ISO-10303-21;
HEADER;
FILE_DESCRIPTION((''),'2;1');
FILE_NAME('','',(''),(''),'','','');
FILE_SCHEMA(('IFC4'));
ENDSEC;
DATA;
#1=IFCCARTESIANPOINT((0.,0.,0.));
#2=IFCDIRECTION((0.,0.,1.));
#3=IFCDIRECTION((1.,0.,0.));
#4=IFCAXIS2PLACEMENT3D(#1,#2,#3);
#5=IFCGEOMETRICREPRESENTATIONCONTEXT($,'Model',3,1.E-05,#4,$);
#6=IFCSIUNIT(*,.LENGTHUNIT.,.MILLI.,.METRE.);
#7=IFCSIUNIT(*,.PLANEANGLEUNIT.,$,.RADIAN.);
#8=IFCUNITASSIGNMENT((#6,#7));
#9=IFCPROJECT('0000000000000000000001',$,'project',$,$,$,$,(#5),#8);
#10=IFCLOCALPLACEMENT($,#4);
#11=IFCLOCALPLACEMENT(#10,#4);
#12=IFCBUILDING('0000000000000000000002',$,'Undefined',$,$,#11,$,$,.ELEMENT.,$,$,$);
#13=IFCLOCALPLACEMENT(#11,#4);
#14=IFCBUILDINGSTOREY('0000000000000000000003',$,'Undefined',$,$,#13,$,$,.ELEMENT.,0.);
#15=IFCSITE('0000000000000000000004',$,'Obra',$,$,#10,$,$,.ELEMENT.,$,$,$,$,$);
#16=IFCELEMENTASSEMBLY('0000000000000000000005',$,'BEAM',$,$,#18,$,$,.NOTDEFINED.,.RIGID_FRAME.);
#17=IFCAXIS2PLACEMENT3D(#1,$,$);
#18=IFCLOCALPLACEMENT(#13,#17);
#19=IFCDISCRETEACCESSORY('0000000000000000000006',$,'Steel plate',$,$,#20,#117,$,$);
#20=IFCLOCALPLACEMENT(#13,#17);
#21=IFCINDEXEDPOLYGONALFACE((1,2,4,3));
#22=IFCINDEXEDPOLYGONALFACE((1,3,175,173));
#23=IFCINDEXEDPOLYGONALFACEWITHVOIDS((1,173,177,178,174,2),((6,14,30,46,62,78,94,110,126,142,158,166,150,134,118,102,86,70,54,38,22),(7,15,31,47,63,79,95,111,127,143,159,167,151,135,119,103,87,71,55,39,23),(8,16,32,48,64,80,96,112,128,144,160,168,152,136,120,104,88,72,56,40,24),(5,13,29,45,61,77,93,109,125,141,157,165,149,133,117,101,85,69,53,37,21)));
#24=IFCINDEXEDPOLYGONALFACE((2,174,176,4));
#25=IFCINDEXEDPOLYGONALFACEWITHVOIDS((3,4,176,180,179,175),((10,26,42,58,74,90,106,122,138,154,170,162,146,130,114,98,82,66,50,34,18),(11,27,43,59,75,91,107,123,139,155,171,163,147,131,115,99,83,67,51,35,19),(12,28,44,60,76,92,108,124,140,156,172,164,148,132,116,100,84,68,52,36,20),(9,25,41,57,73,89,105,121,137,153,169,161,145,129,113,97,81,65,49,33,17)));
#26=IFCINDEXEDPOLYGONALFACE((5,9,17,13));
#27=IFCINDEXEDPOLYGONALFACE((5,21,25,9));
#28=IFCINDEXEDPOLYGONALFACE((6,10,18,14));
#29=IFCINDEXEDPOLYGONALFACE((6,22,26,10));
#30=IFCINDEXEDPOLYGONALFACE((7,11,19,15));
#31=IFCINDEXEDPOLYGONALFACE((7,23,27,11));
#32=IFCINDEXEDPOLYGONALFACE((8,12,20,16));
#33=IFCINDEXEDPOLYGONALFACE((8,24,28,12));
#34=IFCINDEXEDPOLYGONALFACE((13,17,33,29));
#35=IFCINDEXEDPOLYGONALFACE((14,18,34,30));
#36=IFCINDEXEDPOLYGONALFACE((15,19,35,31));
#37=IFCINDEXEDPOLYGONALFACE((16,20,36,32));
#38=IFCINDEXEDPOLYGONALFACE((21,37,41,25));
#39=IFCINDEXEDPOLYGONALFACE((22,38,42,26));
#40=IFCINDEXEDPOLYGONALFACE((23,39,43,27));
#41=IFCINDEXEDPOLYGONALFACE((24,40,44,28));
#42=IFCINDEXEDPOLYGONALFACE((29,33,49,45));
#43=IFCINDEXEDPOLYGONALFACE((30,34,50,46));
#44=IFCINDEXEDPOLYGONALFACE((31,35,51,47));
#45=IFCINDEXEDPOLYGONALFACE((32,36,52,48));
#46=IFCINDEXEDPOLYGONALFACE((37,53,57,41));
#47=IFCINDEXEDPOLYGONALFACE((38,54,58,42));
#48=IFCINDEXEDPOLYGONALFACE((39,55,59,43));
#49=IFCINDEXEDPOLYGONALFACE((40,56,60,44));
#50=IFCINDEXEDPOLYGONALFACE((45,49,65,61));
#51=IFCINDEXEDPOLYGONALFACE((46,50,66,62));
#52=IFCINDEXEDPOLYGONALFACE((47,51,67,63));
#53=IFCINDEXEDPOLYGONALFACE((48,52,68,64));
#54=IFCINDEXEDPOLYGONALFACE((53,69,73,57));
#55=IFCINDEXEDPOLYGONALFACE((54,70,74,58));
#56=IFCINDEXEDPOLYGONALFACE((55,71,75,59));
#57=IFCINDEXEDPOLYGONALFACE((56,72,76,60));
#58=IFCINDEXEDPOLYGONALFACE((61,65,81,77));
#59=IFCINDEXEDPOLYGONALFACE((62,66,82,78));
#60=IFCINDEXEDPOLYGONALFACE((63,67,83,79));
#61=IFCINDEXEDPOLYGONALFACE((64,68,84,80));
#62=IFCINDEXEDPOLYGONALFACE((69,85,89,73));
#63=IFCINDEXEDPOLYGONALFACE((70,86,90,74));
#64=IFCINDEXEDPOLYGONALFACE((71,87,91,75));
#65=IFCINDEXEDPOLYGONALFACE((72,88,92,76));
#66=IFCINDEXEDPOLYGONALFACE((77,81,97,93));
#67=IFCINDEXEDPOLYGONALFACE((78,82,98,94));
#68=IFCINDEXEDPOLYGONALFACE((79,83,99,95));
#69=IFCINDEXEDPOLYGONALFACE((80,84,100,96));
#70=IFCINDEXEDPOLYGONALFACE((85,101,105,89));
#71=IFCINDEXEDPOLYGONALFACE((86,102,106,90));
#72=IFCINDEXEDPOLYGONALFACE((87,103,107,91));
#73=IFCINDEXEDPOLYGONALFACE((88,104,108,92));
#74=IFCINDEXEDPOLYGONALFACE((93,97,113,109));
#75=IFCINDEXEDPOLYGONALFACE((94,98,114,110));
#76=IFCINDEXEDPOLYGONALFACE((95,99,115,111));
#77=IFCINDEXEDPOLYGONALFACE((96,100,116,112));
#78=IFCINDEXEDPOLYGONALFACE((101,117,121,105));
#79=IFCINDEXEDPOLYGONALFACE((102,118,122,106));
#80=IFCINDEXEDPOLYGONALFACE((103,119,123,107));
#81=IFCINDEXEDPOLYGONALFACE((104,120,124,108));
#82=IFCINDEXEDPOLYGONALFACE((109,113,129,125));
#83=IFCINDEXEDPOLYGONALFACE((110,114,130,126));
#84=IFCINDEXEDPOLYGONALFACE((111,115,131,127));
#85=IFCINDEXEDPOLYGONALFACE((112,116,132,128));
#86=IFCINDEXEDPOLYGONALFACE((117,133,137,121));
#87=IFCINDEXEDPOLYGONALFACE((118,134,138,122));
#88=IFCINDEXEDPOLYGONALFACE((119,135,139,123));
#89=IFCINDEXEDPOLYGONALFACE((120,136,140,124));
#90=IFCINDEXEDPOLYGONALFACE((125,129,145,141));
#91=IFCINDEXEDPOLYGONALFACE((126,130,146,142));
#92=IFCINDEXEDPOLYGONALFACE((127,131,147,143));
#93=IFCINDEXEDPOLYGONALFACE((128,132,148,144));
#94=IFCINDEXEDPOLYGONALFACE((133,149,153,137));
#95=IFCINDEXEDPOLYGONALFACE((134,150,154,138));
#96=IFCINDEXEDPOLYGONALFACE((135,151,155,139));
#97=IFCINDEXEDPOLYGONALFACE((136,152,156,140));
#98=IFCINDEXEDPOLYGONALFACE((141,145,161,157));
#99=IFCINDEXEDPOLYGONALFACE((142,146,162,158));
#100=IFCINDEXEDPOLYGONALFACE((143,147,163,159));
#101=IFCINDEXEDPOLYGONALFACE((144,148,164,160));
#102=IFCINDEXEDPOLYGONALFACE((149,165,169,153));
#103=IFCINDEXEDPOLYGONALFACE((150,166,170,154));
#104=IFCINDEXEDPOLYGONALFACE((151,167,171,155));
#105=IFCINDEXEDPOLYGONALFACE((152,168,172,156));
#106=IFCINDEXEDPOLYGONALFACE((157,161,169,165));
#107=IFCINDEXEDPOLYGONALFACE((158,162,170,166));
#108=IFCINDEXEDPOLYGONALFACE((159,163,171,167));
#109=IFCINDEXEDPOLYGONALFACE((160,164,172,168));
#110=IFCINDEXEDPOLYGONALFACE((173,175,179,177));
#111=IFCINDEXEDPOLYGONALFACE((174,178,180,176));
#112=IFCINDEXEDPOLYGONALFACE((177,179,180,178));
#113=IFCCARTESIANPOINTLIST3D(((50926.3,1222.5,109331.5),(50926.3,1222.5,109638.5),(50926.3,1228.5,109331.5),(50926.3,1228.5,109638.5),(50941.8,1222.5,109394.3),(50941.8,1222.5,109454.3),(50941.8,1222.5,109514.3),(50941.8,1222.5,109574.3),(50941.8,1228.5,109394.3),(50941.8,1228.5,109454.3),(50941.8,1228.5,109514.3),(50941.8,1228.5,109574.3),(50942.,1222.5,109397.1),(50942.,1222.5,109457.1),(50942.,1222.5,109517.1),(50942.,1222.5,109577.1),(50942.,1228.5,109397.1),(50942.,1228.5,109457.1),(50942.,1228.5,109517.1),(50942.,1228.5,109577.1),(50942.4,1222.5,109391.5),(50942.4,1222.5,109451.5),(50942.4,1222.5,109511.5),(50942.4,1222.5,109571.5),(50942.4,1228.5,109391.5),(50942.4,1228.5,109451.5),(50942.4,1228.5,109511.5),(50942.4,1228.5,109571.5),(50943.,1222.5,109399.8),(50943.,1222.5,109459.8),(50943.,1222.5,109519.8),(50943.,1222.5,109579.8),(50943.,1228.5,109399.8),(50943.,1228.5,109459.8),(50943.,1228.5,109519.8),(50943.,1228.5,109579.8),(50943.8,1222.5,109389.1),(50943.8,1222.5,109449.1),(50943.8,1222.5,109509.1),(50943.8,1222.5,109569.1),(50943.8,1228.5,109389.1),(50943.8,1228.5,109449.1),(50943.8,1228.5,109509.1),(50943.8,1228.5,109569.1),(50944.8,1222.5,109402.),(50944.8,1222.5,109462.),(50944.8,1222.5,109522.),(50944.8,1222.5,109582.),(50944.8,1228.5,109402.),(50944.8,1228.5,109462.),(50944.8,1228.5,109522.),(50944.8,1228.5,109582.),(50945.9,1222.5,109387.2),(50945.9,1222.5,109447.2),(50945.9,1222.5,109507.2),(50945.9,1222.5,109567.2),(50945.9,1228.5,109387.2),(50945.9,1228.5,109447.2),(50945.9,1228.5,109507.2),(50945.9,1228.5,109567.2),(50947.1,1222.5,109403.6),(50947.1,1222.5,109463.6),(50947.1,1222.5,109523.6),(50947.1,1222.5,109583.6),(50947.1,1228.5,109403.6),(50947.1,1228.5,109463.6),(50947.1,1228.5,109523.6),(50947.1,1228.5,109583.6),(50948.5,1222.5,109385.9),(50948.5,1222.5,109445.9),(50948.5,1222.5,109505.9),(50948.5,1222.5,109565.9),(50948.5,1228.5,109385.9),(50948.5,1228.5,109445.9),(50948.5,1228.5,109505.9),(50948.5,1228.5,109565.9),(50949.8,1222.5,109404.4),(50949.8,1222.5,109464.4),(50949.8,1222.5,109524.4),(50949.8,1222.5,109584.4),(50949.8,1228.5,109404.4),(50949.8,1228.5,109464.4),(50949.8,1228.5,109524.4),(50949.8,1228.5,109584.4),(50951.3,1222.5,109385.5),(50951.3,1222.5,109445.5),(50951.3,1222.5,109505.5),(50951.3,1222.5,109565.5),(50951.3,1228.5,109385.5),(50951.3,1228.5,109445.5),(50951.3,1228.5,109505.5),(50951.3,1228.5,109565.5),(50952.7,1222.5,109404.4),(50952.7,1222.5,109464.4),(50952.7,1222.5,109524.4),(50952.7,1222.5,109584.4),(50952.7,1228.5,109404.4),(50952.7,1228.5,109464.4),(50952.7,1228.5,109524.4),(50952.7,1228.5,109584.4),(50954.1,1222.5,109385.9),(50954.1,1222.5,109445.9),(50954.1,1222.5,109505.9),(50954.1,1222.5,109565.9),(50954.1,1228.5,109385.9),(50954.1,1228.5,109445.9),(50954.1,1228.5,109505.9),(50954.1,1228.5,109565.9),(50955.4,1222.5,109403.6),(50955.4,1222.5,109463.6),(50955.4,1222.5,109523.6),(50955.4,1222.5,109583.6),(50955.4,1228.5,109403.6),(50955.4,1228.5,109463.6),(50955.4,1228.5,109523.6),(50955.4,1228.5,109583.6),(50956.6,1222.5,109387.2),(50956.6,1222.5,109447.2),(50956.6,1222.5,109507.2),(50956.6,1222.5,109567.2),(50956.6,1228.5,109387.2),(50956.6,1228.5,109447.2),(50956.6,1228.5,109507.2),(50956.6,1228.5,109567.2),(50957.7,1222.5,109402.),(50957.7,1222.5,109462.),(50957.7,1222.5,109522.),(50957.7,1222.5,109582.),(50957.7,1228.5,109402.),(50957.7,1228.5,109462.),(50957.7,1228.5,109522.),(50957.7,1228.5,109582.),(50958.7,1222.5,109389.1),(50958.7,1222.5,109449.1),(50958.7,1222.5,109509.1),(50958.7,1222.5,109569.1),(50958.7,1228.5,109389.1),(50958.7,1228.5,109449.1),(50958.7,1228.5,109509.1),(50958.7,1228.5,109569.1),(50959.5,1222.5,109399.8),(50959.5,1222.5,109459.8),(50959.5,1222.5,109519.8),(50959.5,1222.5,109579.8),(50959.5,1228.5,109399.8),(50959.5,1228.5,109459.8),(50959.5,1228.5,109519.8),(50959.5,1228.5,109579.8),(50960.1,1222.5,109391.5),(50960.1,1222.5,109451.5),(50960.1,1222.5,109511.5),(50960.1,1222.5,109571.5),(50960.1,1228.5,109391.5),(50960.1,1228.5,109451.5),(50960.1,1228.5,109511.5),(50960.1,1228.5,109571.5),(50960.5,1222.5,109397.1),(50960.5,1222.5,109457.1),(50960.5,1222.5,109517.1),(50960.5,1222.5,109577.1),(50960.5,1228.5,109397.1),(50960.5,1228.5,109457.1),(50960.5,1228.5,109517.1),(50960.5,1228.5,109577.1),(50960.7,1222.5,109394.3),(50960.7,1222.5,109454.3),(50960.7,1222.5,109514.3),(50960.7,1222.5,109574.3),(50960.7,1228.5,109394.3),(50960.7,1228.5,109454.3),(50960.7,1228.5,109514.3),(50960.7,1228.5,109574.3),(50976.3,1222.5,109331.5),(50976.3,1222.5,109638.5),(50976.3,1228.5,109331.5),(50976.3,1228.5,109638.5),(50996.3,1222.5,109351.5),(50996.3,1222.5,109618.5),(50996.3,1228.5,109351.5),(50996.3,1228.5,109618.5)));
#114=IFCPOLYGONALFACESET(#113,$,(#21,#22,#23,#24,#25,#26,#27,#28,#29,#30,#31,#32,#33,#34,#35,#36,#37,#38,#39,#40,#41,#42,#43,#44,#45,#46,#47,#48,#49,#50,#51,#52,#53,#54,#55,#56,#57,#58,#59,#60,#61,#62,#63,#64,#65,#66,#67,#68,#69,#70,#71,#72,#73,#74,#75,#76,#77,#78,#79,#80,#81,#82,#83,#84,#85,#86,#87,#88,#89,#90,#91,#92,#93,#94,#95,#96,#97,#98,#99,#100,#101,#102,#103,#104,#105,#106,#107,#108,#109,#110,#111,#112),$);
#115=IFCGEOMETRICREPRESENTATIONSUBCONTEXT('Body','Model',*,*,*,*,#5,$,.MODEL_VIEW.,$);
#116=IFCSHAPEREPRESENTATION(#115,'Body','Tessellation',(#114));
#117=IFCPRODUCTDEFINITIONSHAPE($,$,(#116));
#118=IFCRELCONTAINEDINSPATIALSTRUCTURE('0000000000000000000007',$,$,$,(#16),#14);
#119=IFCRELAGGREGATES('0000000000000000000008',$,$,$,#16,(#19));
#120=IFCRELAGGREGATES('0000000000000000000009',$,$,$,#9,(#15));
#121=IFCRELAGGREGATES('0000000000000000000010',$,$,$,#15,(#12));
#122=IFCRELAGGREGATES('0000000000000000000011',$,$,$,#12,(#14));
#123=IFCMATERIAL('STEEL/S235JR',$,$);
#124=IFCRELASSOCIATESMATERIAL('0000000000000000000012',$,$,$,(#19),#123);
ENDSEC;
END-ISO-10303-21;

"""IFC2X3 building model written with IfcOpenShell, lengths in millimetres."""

from ifc_helpers import new_model, si_unit, frame, origin_with_axes, origin_2d_with_axis, place, context, subcontext, project, spatial, polyline, circle, outline, extrude, source, transform, mapped, material, element, aggregate, save


model = new_model("IFC2X3")

# Units and contexts
model_context = context("Model", 3, precision=1e-05, world=origin_with_axes())
body_context = subcontext(model_context, "Body", "Model", "MODEL_VIEW")
ifc_project = project(units=[si_unit("LENGTHUNIT", "METRE", prefix="MILLI"), si_unit("PLANEANGLEUNIT", "RADIAN")], contexts=[model_context])

# Site, building, storey
site_placement = place(None, origin_with_axes())
site = spatial("IfcSite", under=ifc_project, at=site_placement, Name="Obra", CompositionType="ELEMENT")
building_placement = place(site_placement, origin_with_axes())
building = spatial("IfcBuilding", under=site, at=building_placement, Name="Undefined", CompositionType="ELEMENT")
storey_placement = place(building_placement, origin_with_axes())
storey = spatial("IfcBuildingStorey", under=building, at=storey_placement, Name="Undefined", CompositionType="ELEMENT", Elevation=0.0)

# Shared definitions
ifc_material = material(Name="STEEL/S235JR")
shared_shape = source(origin_with_axes(), body_context, "Body", "SweptSolid", [
    extrude(circle(Radius=9.5, at=origin_2d_with_axis()), frame((0.0, -9.8, 0.0), z_axis=(0.0, 1.0, 0.0), x_axis=(1.0, 0.0, 0.0)), (0.0, 0.0, 1.0), 6.2),
])

# Element assembly, discrete accessory, opening
assembly_1_placement = place(storey_placement, origin_with_axes())
assembly_1 = element("IfcElementAssembly", 1, at=assembly_1_placement, inside=storey, Name="BEAM", AssemblyPlace="NOTDEFINED", PredefinedType="RIGID_FRAME")
discrete_accessory_1_placement = place(assembly_1_placement, frame((50926.3, 1225.5, 109331.5), z_axis=(0.0, -1.0, 0.0), x_axis=(1.0, 0.0, 0.0)))
discrete_accessory_1 = element("IfcDiscreteAccessory", 2, at=discrete_accessory_1_placement, material=ifc_material, Name="Steel plate", context=body_context, shape_type="SweptSolid", body=[
    extrude(outline(polyline([(0.0, 0.0), (50.0, 0.0), (70.0, 20.0), (70.0, 287.0), (50.0, 307.0), (0.0, 307.0), (0.0, 0.0)])), frame((0.0, 0.0, -3.0), z_axis=(0.0, 0.0, 1.0), x_axis=(1.0, 0.0, 0.0)), (0.0, 0.0, 1.0), 6.0),
])
opening_1_placement = place(assembly_1_placement, frame((50986.3, 1218.8, 109650.0), z_axis=(-1.0, 0.0, 0.0), x_axis=(0.0, 0.0, -1.0)))
element("IfcOpeningElement", 3, at=opening_1_placement, cuts=discrete_accessory_1, ObjectType="Opening", context=body_context, shape_type="MappedRepresentation", body=[
    mapped(shared_shape, transform((75.0, 0.0, 35.0))),
    mapped(shared_shape, transform((135.0, 0.0, 35.0))),
    mapped(shared_shape, transform((195.0, 0.0, 35.0))),
    mapped(shared_shape, transform((255.0, 0.0, 35.0))),
])
aggregate(assembly_1, [discrete_accessory_1])

save(model, "model.ifc")
